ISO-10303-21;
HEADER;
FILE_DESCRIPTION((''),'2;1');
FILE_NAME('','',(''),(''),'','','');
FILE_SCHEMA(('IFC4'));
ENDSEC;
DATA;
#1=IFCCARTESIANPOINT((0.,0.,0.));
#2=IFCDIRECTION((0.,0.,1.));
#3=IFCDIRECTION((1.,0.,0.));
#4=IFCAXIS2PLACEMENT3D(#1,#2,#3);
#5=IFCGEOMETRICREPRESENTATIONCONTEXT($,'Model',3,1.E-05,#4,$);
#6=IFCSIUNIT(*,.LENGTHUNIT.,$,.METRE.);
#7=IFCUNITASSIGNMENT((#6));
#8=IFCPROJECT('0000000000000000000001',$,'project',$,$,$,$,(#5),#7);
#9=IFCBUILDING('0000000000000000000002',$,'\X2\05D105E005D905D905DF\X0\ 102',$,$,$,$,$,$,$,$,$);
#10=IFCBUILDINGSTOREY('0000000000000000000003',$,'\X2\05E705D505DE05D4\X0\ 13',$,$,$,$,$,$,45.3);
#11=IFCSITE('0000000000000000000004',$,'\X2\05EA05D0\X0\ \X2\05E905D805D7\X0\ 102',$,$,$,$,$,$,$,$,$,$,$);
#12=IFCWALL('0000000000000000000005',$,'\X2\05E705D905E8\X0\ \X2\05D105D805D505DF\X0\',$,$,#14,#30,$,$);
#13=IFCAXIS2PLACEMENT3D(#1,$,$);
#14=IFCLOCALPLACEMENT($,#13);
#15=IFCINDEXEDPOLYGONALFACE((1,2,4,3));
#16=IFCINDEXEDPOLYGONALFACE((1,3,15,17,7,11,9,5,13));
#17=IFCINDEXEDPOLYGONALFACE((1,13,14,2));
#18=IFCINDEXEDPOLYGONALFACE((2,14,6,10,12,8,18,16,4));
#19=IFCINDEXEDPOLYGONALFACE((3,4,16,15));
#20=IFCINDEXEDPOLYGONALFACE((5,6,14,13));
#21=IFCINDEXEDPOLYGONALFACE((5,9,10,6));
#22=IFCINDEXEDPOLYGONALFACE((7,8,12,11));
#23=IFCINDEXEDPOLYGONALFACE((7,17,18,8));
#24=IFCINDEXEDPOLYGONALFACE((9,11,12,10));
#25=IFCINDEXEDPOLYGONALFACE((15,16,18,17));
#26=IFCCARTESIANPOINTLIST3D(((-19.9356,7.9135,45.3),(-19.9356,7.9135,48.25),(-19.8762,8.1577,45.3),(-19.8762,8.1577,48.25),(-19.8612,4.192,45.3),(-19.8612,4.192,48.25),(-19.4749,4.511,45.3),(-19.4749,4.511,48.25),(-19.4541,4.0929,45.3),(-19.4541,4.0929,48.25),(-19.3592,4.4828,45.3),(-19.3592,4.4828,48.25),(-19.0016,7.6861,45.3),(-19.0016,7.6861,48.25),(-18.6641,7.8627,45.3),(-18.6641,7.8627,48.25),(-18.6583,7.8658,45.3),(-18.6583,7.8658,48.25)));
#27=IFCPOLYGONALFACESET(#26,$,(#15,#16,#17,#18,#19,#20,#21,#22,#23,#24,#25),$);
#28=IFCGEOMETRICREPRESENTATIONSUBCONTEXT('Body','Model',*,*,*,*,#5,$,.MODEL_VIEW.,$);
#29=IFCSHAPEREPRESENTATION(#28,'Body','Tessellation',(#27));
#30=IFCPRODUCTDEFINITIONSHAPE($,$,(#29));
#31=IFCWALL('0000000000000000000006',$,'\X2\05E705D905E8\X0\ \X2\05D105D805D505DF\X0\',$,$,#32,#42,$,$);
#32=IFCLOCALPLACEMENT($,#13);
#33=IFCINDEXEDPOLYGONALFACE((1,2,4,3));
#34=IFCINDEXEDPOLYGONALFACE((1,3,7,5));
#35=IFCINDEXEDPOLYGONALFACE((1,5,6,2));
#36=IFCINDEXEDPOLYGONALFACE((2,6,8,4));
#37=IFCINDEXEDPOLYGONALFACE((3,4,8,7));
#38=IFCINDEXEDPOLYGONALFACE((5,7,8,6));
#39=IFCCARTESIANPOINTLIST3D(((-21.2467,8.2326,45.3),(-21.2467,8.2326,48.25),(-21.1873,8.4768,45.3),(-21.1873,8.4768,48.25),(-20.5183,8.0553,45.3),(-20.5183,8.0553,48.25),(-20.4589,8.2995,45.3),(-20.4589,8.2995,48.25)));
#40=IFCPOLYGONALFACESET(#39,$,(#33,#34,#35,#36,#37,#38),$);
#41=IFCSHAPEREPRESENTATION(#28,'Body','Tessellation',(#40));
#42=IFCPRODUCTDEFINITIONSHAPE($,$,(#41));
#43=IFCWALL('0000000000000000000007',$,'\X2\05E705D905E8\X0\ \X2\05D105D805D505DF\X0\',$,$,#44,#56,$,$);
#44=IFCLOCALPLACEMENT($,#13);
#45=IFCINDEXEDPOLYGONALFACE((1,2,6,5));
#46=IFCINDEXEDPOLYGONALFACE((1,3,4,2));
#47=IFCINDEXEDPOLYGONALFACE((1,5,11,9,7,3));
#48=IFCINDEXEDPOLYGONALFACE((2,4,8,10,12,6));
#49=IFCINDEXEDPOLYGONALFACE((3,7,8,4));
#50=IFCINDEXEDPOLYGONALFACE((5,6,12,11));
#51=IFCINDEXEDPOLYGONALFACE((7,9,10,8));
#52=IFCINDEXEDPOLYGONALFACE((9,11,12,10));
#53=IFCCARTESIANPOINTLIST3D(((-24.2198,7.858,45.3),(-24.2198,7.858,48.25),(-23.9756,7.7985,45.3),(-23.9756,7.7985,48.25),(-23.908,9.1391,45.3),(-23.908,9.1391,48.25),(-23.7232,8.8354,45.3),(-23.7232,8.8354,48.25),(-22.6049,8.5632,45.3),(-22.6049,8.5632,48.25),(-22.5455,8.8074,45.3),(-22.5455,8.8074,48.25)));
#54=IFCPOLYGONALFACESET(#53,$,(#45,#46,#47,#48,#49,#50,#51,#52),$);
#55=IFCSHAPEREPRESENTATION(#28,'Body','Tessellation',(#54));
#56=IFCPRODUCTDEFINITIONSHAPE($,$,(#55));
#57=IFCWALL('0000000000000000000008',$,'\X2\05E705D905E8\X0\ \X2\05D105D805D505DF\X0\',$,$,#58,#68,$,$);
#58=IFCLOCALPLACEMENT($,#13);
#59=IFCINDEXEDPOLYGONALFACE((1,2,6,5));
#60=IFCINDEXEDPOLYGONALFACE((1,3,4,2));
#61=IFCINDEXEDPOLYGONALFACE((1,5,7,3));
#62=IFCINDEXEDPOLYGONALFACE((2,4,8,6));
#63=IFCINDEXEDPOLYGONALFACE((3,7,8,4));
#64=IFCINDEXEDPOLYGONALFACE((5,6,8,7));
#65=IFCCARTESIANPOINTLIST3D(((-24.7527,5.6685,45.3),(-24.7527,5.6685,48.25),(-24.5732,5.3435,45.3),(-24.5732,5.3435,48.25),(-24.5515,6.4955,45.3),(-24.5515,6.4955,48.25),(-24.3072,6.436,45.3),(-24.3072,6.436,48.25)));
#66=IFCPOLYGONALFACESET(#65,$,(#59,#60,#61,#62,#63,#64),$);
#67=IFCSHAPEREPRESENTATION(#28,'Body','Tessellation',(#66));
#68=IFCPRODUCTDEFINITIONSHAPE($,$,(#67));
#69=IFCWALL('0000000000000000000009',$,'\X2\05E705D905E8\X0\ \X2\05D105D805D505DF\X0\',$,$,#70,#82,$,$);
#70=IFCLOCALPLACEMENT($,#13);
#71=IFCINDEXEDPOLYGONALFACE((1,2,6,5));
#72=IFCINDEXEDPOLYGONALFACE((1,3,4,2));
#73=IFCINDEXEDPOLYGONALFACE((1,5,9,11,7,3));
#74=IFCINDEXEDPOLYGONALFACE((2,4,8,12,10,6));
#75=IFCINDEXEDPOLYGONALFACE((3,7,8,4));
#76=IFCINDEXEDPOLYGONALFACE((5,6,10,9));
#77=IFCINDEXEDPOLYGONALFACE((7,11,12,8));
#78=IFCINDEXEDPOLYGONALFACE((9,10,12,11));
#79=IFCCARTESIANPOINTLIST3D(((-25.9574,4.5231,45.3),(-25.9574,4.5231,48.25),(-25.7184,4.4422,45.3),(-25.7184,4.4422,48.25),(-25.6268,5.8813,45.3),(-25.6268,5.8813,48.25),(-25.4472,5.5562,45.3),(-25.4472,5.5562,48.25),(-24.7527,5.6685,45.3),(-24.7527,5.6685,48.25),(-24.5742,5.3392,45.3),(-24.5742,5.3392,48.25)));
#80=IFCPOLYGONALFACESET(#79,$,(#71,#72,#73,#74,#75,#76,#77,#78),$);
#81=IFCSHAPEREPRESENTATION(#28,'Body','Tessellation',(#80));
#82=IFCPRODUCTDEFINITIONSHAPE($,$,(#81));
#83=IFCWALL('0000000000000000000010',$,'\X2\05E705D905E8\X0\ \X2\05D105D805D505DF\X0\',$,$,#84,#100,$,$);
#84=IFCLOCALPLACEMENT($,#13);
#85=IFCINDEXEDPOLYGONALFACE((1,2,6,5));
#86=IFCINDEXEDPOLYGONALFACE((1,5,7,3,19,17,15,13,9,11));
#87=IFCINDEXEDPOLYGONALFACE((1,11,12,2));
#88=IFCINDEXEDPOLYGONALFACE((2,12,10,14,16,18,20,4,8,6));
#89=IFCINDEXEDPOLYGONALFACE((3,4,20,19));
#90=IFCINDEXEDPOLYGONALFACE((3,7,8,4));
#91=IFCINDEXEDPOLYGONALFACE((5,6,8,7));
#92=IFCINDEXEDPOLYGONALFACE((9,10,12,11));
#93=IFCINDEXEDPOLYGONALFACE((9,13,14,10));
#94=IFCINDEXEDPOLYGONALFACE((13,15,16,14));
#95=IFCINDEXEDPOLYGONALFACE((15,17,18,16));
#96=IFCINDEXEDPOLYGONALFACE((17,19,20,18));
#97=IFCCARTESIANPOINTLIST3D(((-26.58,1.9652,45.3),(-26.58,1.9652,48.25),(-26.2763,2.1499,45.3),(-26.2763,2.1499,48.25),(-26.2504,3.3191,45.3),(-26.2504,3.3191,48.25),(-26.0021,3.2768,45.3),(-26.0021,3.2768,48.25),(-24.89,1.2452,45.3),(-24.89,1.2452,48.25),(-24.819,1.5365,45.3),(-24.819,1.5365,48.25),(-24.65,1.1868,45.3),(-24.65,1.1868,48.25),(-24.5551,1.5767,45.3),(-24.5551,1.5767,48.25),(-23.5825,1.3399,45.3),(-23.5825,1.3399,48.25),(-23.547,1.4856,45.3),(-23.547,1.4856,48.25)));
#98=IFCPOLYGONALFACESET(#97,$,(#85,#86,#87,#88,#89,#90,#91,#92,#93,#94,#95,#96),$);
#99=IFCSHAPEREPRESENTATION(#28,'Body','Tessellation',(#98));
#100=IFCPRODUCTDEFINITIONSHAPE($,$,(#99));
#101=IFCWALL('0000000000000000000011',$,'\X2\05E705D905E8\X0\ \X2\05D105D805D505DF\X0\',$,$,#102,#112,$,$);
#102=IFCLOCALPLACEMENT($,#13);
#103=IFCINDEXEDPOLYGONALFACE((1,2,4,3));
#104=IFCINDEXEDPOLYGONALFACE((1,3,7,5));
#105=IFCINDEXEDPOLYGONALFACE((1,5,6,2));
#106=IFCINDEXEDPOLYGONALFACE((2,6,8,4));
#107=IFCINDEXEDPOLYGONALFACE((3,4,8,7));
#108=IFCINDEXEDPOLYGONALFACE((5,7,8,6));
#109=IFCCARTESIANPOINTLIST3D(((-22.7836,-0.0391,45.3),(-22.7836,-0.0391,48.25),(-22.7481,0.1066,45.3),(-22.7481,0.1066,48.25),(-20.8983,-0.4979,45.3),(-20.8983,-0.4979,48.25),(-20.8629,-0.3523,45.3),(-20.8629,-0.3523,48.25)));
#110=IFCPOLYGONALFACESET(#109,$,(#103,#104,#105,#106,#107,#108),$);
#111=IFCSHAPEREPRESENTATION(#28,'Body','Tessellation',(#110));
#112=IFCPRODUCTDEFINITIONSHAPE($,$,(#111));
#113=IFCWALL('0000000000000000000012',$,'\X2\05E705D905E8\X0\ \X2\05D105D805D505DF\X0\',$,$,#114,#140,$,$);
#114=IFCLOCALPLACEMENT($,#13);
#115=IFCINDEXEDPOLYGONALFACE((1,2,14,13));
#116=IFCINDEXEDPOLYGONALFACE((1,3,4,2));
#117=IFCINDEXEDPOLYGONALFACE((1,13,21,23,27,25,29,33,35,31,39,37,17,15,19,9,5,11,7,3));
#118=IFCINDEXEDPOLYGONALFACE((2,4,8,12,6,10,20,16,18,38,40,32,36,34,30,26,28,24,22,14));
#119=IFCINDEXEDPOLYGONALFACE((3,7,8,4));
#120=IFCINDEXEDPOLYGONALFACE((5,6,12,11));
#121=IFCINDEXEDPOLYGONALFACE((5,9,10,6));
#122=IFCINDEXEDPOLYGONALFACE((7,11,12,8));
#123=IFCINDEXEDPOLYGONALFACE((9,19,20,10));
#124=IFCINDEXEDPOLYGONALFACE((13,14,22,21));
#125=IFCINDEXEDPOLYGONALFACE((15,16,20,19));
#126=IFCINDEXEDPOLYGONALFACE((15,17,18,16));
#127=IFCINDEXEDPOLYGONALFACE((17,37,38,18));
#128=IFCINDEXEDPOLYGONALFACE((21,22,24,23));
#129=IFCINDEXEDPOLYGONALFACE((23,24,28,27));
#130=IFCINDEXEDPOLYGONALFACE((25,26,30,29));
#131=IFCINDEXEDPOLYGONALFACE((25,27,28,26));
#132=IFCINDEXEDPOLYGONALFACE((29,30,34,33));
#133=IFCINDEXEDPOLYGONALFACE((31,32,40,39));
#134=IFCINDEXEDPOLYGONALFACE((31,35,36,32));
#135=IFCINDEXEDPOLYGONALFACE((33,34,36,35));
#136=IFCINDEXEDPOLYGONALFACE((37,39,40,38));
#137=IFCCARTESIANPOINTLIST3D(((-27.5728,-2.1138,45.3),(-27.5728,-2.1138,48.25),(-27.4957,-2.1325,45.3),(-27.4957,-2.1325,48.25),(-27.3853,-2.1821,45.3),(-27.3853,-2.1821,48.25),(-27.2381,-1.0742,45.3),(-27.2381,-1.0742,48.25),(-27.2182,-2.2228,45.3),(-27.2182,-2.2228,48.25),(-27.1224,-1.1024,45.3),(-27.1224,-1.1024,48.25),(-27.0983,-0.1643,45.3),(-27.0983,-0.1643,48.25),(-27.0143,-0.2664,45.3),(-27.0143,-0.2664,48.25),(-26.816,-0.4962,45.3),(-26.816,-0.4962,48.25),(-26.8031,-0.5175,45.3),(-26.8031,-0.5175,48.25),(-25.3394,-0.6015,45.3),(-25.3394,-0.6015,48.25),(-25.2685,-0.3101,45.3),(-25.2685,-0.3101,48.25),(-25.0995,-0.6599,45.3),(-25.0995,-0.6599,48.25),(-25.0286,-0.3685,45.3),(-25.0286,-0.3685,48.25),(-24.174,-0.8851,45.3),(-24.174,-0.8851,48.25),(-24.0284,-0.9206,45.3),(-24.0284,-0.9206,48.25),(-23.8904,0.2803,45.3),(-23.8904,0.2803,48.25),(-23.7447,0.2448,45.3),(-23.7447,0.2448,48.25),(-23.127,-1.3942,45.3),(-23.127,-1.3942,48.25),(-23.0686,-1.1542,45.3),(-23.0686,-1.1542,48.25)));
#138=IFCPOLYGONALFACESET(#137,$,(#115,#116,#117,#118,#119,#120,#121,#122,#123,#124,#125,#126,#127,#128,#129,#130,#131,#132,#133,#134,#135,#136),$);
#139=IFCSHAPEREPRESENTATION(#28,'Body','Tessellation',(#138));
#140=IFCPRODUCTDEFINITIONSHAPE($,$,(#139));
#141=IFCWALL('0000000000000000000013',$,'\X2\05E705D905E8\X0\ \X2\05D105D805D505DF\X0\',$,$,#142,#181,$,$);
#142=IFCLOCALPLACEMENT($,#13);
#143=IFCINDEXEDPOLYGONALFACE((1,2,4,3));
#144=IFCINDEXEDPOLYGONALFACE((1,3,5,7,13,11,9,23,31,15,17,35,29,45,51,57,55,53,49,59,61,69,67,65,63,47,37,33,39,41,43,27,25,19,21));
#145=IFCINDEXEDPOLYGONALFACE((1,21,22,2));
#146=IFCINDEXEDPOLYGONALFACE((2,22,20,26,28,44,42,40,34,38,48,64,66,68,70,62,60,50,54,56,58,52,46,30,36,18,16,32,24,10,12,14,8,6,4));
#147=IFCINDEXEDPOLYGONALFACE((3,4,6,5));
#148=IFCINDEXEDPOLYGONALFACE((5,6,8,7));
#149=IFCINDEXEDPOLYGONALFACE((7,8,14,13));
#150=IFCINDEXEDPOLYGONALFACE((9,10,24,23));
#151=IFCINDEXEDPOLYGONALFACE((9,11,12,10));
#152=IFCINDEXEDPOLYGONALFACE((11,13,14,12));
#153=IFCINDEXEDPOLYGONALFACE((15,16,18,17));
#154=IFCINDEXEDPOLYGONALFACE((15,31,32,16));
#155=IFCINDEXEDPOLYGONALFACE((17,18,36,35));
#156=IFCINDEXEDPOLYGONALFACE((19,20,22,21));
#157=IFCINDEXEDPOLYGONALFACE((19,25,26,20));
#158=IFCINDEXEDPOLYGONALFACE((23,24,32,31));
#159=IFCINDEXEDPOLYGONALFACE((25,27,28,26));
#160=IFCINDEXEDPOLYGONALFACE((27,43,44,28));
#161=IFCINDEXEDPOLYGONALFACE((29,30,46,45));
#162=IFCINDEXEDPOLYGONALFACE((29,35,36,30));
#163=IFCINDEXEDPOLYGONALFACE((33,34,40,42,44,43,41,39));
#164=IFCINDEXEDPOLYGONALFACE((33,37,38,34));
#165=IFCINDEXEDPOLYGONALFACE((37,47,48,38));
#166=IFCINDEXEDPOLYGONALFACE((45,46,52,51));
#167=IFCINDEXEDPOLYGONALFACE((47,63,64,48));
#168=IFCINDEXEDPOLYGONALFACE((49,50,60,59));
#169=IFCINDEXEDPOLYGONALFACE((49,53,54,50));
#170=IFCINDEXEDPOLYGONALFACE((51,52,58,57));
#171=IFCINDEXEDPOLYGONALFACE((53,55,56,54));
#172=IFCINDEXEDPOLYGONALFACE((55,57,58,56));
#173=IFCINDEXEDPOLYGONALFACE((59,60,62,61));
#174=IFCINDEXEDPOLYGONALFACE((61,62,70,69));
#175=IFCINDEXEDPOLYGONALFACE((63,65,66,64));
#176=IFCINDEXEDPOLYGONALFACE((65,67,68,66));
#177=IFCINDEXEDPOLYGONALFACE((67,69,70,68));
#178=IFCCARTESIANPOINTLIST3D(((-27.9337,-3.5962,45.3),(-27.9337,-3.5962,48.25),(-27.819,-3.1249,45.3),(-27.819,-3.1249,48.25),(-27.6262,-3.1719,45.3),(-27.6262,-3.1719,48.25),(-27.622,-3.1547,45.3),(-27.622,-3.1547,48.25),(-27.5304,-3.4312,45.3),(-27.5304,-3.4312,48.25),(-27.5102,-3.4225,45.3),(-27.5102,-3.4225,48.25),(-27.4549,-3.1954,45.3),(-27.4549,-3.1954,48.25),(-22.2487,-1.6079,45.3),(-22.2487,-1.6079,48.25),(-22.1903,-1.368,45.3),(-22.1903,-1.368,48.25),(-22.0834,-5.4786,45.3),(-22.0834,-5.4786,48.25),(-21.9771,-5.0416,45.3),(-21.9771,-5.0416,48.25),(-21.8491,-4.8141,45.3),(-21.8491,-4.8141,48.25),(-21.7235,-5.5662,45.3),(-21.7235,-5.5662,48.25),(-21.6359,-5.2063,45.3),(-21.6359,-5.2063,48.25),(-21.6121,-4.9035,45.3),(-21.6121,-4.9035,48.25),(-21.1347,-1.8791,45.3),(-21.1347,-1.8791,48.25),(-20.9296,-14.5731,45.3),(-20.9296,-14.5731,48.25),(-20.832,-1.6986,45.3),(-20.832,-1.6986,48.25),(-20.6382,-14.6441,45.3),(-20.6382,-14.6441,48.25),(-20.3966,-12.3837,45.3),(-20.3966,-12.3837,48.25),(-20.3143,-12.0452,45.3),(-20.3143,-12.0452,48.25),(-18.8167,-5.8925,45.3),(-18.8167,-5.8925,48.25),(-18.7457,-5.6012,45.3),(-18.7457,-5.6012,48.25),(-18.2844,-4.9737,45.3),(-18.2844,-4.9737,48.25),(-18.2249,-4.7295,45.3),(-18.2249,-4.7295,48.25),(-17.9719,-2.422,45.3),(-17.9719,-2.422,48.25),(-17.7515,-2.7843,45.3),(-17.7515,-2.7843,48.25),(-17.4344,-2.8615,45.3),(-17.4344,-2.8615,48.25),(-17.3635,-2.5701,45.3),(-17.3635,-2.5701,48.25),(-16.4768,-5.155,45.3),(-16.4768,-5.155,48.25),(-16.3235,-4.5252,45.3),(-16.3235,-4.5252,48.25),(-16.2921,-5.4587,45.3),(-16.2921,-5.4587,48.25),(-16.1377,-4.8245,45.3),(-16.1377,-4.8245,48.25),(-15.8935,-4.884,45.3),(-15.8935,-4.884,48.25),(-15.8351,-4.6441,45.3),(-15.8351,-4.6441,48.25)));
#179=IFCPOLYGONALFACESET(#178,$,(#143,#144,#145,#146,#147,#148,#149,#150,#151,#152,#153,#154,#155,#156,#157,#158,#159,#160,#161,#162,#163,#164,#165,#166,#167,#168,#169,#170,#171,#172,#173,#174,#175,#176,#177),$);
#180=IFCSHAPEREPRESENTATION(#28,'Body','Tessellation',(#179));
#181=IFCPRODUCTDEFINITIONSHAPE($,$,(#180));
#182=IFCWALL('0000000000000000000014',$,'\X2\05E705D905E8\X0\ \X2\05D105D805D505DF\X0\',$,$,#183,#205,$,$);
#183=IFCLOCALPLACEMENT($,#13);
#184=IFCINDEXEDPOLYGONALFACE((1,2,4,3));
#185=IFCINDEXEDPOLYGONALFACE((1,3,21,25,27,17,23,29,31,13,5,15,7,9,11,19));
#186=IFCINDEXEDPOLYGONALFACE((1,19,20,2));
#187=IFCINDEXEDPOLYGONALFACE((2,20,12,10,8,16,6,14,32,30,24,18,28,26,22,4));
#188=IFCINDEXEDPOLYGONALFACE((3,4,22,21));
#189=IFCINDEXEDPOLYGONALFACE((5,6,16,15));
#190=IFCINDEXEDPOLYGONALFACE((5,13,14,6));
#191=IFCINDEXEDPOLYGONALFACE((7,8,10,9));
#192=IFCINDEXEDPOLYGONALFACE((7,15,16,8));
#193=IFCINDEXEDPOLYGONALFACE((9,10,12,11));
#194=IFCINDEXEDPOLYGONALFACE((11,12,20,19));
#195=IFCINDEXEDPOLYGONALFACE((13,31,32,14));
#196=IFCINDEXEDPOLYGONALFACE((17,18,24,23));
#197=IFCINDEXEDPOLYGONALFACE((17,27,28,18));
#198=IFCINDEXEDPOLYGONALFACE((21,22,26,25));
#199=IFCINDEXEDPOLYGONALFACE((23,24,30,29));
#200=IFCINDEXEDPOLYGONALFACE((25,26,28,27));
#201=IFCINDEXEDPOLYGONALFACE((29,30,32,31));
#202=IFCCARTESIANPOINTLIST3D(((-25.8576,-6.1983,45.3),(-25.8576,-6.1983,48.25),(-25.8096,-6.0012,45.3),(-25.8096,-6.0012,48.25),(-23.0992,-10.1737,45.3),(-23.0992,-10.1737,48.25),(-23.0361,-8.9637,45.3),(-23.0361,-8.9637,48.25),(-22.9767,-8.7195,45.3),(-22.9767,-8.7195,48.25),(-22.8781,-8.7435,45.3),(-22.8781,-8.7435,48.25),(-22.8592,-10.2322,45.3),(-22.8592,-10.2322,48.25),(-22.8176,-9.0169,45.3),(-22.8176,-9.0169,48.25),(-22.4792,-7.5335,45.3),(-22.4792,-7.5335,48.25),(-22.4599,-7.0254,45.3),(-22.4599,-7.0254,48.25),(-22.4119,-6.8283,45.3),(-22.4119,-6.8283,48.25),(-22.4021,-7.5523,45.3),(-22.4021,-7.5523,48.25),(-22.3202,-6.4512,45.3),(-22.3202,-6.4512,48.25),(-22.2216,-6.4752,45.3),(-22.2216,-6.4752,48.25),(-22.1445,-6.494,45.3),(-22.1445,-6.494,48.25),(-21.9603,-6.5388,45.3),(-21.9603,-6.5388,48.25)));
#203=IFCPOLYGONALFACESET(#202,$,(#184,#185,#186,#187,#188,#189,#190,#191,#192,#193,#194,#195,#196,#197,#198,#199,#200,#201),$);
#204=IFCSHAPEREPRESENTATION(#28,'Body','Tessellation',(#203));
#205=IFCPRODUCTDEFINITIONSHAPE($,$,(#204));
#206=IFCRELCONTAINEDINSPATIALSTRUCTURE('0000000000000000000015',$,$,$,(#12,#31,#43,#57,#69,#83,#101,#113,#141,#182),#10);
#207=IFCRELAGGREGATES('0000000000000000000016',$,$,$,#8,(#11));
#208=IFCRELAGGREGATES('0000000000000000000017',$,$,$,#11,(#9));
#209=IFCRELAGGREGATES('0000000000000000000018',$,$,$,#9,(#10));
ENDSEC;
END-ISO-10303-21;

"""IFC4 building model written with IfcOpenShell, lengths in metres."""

from ifc_helpers import new_model, si_unit, frame, origin_with_axes, context, subcontext, project, spatial, polyline, outline, extrude, element, save


model = new_model("IFC4")

# Units and contexts
model_context = context("Model", 3, precision=1e-05, world=origin_with_axes())
body_context = subcontext(model_context, "Body", "Model", "MODEL_VIEW")
ifc_project = project(units=[si_unit("LENGTHUNIT", "METRE")], contexts=[model_context])

# Site, building, storey
site = spatial("IfcSite", under=ifc_project, Name="תא שטח 102")
building = spatial("IfcBuilding", under=site, Name="בניין 102")
storey = spatial("IfcBuildingStorey", under=building, Name="קומה 13", Elevation=45.3)

# Walls
element("IfcWall", 1, inside=storey, Name="קיר בטון", context=body_context, shape_type="SweptSolid", body=[
    extrude(outline(polyline([(-19.0016, 7.6861), (-19.8612, 4.192), (-19.4541, 4.0929), (-19.3592, 4.4828), (-19.4749, 4.511), (-18.6583, 7.8658), (-18.7159, 7.8344), (-18.6636, 7.8626), (-19.8762, 8.1577), (-19.9356, 7.9135), (-19.0016, 7.6861)])), frame((0.0, 0.0, 45.3)), (0.0, 0.0, 1.0), 2.95),
])
element("IfcWall", 2, inside=storey, Name="קיר בטון", context=body_context, shape_type="SweptSolid", body=[
    extrude(outline(polyline([(-20.4589, 8.2995), (-21.1873, 8.4768), (-21.2467, 8.2326), (-20.5183, 8.0553), (-20.4589, 8.2995)])), frame((0.0, 0.0, 45.3)), (0.0, 0.0, 1.0), 2.95),
])
element("IfcWall", 3, inside=storey, Name="קיר בטון", context=body_context, shape_type="SweptSolid", body=[
    extrude(outline(polyline([(-24.2198, 7.858), (-23.9756, 7.7985), (-23.7232, 8.8354), (-22.6049, 8.5632), (-22.5455, 8.8074), (-23.908, 9.1391), (-24.2198, 7.858)])), frame((0.0, 0.0, 45.3)), (0.0, 0.0, 1.0), 2.95),
])
element("IfcWall", 4, inside=storey, Name="קיר בטון", context=body_context, shape_type="SweptSolid", body=[
    extrude(outline(polyline([(-24.7527, 5.6685), (-24.5732, 5.3435), (-24.3072, 6.436), (-24.5515, 6.4955), (-24.7527, 5.6685)])), frame((0.0, 0.0, 45.3)), (0.0, 0.0, 1.0), 2.95),
])
element("IfcWall", 5, inside=storey, Name="קיר בטון", context=body_context, shape_type="SweptSolid", body=[
    extrude(outline(polyline([(-25.9574, 4.5231), (-25.7184, 4.4422), (-25.4472, 5.5562), (-24.5742, 5.3392), (-24.7527, 5.6685), (-25.6268, 5.8813), (-25.9574, 4.5231)])), frame((0.0, 0.0, 45.3)), (0.0, 0.0, 1.0), 2.95),
])
element("IfcWall", 6, inside=storey, Name="קיר בטון", context=body_context, shape_type="SweptSolid", body=[
    extrude(outline(polyline([(-26.58, 1.9652), (-24.819, 1.5365), (-24.89, 1.2452), (-24.65, 1.1868), (-24.5551, 1.5767), (-23.5825, 1.3399), (-23.547, 1.4856), (-26.2763, 2.1499), (-26.0021, 3.2768), (-26.2504, 3.3191), (-26.58, 1.9652)])), frame((0.0, 0.0, 45.3)), (0.0, 0.0, 1.0), 2.95),
])
element("IfcWall", 7, inside=storey, Name="קיר בטון", context=body_context, shape_type="SweptSolid", body=[
    extrude(outline(polyline([(-22.7836, -0.0391), (-20.8983, -0.4979), (-20.8629, -0.3523), (-22.7481, 0.1066), (-22.7836, -0.0391)])), frame((0.0, 0.0, 45.3)), (0.0, 0.0, 1.0), 2.95),
])
element("IfcWall", 8, inside=storey, Name="קיר בטון", context=body_context, shape_type="SweptSolid", body=[
    extrude(outline(polyline([(-25.3394, -0.6015), (-27.0983, -0.1643), (-27.5728, -2.1138), (-27.4957, -2.1325), (-27.2381, -1.0742), (-27.1224, -1.1024), (-27.3853, -2.1821), (-27.2182, -2.2228), (-26.8031, -0.5175), (-27.0143, -0.2664), (-26.816, -0.4962), (-23.127, -1.3942), (-23.0686, -1.1542), (-24.0284, -0.9206), (-23.7447, 0.2448), (-23.8904, 0.2803), (-24.174, -0.8851), (-25.0995, -0.6599), (-25.0286, -0.3685), (-25.2685, -0.3101), (-25.3394, -0.6015)])), frame((0.0, 0.0, 45.3)), (0.0, 0.0, 1.0), 2.95),
])
element("IfcWall", 9, inside=storey, Name="קיר בטון", context=body_context, shape_type="SweptSolid", body=[
    extrude(outline(polyline([(-21.8491, -4.8141), (-27.5304, -3.4312), (-27.5102, -3.4225), (-27.4549, -3.1954), (-27.622, -3.1547), (-27.6262, -3.1719), (-27.819, -3.1249), (-27.9337, -3.5962), (-21.9771, -5.0416), (-22.0834, -5.4786), (-21.7235, -5.5662), (-21.6359, -5.2063), (-18.8167, -5.8925), (-20.3143, -12.0452), (-20.3966, -12.3837), (-20.9296, -14.5731), (-20.6382, -14.6441), (-18.2844, -4.9737), (-16.2921, -5.4587), (-16.1377, -4.8245), (-15.8935, -4.884), (-15.8351, -4.6441), (-16.3235, -4.5252), (-16.4768, -5.155), (-18.2249, -4.7295), (-17.7515, -2.7843), (-17.4344, -2.8615), (-17.3635, -2.5701), (-17.9719, -2.422), (-18.7457, -5.6012), (-21.6121, -4.9035), (-20.832, -1.6986), (-22.1903, -1.368), (-22.2487, -1.6079), (-21.1347, -1.8791), (-21.8491, -4.8141)])), frame((0.0, 0.0, 45.3)), (0.0, 0.0, 1.0), 2.95),
])
element("IfcWall", 10, inside=storey, Name="קיר בטון", context=body_context, shape_type="SweptSolid", body=[
    extrude(outline(polyline([(-25.8576, -6.1983), (-22.4599, -7.0254), (-22.8781, -8.7435), (-22.9767, -8.7195), (-23.0361, -8.9637), (-22.8176, -9.0169), (-23.0992, -10.1737), (-22.8592, -10.2322), (-21.9603, -6.5388), (-22.1445, -6.494), (-22.4021, -7.5523), (-22.4792, -7.5335), (-22.2216, -6.4752), (-22.3202, -6.4512), (-22.4119, -6.8283), (-25.8096, -6.0012), (-25.8576, -6.1983)])), frame((0.0, 0.0, 45.3)), (0.0, 0.0, 1.0), 2.95),
])

save(model, "model.ifc")
